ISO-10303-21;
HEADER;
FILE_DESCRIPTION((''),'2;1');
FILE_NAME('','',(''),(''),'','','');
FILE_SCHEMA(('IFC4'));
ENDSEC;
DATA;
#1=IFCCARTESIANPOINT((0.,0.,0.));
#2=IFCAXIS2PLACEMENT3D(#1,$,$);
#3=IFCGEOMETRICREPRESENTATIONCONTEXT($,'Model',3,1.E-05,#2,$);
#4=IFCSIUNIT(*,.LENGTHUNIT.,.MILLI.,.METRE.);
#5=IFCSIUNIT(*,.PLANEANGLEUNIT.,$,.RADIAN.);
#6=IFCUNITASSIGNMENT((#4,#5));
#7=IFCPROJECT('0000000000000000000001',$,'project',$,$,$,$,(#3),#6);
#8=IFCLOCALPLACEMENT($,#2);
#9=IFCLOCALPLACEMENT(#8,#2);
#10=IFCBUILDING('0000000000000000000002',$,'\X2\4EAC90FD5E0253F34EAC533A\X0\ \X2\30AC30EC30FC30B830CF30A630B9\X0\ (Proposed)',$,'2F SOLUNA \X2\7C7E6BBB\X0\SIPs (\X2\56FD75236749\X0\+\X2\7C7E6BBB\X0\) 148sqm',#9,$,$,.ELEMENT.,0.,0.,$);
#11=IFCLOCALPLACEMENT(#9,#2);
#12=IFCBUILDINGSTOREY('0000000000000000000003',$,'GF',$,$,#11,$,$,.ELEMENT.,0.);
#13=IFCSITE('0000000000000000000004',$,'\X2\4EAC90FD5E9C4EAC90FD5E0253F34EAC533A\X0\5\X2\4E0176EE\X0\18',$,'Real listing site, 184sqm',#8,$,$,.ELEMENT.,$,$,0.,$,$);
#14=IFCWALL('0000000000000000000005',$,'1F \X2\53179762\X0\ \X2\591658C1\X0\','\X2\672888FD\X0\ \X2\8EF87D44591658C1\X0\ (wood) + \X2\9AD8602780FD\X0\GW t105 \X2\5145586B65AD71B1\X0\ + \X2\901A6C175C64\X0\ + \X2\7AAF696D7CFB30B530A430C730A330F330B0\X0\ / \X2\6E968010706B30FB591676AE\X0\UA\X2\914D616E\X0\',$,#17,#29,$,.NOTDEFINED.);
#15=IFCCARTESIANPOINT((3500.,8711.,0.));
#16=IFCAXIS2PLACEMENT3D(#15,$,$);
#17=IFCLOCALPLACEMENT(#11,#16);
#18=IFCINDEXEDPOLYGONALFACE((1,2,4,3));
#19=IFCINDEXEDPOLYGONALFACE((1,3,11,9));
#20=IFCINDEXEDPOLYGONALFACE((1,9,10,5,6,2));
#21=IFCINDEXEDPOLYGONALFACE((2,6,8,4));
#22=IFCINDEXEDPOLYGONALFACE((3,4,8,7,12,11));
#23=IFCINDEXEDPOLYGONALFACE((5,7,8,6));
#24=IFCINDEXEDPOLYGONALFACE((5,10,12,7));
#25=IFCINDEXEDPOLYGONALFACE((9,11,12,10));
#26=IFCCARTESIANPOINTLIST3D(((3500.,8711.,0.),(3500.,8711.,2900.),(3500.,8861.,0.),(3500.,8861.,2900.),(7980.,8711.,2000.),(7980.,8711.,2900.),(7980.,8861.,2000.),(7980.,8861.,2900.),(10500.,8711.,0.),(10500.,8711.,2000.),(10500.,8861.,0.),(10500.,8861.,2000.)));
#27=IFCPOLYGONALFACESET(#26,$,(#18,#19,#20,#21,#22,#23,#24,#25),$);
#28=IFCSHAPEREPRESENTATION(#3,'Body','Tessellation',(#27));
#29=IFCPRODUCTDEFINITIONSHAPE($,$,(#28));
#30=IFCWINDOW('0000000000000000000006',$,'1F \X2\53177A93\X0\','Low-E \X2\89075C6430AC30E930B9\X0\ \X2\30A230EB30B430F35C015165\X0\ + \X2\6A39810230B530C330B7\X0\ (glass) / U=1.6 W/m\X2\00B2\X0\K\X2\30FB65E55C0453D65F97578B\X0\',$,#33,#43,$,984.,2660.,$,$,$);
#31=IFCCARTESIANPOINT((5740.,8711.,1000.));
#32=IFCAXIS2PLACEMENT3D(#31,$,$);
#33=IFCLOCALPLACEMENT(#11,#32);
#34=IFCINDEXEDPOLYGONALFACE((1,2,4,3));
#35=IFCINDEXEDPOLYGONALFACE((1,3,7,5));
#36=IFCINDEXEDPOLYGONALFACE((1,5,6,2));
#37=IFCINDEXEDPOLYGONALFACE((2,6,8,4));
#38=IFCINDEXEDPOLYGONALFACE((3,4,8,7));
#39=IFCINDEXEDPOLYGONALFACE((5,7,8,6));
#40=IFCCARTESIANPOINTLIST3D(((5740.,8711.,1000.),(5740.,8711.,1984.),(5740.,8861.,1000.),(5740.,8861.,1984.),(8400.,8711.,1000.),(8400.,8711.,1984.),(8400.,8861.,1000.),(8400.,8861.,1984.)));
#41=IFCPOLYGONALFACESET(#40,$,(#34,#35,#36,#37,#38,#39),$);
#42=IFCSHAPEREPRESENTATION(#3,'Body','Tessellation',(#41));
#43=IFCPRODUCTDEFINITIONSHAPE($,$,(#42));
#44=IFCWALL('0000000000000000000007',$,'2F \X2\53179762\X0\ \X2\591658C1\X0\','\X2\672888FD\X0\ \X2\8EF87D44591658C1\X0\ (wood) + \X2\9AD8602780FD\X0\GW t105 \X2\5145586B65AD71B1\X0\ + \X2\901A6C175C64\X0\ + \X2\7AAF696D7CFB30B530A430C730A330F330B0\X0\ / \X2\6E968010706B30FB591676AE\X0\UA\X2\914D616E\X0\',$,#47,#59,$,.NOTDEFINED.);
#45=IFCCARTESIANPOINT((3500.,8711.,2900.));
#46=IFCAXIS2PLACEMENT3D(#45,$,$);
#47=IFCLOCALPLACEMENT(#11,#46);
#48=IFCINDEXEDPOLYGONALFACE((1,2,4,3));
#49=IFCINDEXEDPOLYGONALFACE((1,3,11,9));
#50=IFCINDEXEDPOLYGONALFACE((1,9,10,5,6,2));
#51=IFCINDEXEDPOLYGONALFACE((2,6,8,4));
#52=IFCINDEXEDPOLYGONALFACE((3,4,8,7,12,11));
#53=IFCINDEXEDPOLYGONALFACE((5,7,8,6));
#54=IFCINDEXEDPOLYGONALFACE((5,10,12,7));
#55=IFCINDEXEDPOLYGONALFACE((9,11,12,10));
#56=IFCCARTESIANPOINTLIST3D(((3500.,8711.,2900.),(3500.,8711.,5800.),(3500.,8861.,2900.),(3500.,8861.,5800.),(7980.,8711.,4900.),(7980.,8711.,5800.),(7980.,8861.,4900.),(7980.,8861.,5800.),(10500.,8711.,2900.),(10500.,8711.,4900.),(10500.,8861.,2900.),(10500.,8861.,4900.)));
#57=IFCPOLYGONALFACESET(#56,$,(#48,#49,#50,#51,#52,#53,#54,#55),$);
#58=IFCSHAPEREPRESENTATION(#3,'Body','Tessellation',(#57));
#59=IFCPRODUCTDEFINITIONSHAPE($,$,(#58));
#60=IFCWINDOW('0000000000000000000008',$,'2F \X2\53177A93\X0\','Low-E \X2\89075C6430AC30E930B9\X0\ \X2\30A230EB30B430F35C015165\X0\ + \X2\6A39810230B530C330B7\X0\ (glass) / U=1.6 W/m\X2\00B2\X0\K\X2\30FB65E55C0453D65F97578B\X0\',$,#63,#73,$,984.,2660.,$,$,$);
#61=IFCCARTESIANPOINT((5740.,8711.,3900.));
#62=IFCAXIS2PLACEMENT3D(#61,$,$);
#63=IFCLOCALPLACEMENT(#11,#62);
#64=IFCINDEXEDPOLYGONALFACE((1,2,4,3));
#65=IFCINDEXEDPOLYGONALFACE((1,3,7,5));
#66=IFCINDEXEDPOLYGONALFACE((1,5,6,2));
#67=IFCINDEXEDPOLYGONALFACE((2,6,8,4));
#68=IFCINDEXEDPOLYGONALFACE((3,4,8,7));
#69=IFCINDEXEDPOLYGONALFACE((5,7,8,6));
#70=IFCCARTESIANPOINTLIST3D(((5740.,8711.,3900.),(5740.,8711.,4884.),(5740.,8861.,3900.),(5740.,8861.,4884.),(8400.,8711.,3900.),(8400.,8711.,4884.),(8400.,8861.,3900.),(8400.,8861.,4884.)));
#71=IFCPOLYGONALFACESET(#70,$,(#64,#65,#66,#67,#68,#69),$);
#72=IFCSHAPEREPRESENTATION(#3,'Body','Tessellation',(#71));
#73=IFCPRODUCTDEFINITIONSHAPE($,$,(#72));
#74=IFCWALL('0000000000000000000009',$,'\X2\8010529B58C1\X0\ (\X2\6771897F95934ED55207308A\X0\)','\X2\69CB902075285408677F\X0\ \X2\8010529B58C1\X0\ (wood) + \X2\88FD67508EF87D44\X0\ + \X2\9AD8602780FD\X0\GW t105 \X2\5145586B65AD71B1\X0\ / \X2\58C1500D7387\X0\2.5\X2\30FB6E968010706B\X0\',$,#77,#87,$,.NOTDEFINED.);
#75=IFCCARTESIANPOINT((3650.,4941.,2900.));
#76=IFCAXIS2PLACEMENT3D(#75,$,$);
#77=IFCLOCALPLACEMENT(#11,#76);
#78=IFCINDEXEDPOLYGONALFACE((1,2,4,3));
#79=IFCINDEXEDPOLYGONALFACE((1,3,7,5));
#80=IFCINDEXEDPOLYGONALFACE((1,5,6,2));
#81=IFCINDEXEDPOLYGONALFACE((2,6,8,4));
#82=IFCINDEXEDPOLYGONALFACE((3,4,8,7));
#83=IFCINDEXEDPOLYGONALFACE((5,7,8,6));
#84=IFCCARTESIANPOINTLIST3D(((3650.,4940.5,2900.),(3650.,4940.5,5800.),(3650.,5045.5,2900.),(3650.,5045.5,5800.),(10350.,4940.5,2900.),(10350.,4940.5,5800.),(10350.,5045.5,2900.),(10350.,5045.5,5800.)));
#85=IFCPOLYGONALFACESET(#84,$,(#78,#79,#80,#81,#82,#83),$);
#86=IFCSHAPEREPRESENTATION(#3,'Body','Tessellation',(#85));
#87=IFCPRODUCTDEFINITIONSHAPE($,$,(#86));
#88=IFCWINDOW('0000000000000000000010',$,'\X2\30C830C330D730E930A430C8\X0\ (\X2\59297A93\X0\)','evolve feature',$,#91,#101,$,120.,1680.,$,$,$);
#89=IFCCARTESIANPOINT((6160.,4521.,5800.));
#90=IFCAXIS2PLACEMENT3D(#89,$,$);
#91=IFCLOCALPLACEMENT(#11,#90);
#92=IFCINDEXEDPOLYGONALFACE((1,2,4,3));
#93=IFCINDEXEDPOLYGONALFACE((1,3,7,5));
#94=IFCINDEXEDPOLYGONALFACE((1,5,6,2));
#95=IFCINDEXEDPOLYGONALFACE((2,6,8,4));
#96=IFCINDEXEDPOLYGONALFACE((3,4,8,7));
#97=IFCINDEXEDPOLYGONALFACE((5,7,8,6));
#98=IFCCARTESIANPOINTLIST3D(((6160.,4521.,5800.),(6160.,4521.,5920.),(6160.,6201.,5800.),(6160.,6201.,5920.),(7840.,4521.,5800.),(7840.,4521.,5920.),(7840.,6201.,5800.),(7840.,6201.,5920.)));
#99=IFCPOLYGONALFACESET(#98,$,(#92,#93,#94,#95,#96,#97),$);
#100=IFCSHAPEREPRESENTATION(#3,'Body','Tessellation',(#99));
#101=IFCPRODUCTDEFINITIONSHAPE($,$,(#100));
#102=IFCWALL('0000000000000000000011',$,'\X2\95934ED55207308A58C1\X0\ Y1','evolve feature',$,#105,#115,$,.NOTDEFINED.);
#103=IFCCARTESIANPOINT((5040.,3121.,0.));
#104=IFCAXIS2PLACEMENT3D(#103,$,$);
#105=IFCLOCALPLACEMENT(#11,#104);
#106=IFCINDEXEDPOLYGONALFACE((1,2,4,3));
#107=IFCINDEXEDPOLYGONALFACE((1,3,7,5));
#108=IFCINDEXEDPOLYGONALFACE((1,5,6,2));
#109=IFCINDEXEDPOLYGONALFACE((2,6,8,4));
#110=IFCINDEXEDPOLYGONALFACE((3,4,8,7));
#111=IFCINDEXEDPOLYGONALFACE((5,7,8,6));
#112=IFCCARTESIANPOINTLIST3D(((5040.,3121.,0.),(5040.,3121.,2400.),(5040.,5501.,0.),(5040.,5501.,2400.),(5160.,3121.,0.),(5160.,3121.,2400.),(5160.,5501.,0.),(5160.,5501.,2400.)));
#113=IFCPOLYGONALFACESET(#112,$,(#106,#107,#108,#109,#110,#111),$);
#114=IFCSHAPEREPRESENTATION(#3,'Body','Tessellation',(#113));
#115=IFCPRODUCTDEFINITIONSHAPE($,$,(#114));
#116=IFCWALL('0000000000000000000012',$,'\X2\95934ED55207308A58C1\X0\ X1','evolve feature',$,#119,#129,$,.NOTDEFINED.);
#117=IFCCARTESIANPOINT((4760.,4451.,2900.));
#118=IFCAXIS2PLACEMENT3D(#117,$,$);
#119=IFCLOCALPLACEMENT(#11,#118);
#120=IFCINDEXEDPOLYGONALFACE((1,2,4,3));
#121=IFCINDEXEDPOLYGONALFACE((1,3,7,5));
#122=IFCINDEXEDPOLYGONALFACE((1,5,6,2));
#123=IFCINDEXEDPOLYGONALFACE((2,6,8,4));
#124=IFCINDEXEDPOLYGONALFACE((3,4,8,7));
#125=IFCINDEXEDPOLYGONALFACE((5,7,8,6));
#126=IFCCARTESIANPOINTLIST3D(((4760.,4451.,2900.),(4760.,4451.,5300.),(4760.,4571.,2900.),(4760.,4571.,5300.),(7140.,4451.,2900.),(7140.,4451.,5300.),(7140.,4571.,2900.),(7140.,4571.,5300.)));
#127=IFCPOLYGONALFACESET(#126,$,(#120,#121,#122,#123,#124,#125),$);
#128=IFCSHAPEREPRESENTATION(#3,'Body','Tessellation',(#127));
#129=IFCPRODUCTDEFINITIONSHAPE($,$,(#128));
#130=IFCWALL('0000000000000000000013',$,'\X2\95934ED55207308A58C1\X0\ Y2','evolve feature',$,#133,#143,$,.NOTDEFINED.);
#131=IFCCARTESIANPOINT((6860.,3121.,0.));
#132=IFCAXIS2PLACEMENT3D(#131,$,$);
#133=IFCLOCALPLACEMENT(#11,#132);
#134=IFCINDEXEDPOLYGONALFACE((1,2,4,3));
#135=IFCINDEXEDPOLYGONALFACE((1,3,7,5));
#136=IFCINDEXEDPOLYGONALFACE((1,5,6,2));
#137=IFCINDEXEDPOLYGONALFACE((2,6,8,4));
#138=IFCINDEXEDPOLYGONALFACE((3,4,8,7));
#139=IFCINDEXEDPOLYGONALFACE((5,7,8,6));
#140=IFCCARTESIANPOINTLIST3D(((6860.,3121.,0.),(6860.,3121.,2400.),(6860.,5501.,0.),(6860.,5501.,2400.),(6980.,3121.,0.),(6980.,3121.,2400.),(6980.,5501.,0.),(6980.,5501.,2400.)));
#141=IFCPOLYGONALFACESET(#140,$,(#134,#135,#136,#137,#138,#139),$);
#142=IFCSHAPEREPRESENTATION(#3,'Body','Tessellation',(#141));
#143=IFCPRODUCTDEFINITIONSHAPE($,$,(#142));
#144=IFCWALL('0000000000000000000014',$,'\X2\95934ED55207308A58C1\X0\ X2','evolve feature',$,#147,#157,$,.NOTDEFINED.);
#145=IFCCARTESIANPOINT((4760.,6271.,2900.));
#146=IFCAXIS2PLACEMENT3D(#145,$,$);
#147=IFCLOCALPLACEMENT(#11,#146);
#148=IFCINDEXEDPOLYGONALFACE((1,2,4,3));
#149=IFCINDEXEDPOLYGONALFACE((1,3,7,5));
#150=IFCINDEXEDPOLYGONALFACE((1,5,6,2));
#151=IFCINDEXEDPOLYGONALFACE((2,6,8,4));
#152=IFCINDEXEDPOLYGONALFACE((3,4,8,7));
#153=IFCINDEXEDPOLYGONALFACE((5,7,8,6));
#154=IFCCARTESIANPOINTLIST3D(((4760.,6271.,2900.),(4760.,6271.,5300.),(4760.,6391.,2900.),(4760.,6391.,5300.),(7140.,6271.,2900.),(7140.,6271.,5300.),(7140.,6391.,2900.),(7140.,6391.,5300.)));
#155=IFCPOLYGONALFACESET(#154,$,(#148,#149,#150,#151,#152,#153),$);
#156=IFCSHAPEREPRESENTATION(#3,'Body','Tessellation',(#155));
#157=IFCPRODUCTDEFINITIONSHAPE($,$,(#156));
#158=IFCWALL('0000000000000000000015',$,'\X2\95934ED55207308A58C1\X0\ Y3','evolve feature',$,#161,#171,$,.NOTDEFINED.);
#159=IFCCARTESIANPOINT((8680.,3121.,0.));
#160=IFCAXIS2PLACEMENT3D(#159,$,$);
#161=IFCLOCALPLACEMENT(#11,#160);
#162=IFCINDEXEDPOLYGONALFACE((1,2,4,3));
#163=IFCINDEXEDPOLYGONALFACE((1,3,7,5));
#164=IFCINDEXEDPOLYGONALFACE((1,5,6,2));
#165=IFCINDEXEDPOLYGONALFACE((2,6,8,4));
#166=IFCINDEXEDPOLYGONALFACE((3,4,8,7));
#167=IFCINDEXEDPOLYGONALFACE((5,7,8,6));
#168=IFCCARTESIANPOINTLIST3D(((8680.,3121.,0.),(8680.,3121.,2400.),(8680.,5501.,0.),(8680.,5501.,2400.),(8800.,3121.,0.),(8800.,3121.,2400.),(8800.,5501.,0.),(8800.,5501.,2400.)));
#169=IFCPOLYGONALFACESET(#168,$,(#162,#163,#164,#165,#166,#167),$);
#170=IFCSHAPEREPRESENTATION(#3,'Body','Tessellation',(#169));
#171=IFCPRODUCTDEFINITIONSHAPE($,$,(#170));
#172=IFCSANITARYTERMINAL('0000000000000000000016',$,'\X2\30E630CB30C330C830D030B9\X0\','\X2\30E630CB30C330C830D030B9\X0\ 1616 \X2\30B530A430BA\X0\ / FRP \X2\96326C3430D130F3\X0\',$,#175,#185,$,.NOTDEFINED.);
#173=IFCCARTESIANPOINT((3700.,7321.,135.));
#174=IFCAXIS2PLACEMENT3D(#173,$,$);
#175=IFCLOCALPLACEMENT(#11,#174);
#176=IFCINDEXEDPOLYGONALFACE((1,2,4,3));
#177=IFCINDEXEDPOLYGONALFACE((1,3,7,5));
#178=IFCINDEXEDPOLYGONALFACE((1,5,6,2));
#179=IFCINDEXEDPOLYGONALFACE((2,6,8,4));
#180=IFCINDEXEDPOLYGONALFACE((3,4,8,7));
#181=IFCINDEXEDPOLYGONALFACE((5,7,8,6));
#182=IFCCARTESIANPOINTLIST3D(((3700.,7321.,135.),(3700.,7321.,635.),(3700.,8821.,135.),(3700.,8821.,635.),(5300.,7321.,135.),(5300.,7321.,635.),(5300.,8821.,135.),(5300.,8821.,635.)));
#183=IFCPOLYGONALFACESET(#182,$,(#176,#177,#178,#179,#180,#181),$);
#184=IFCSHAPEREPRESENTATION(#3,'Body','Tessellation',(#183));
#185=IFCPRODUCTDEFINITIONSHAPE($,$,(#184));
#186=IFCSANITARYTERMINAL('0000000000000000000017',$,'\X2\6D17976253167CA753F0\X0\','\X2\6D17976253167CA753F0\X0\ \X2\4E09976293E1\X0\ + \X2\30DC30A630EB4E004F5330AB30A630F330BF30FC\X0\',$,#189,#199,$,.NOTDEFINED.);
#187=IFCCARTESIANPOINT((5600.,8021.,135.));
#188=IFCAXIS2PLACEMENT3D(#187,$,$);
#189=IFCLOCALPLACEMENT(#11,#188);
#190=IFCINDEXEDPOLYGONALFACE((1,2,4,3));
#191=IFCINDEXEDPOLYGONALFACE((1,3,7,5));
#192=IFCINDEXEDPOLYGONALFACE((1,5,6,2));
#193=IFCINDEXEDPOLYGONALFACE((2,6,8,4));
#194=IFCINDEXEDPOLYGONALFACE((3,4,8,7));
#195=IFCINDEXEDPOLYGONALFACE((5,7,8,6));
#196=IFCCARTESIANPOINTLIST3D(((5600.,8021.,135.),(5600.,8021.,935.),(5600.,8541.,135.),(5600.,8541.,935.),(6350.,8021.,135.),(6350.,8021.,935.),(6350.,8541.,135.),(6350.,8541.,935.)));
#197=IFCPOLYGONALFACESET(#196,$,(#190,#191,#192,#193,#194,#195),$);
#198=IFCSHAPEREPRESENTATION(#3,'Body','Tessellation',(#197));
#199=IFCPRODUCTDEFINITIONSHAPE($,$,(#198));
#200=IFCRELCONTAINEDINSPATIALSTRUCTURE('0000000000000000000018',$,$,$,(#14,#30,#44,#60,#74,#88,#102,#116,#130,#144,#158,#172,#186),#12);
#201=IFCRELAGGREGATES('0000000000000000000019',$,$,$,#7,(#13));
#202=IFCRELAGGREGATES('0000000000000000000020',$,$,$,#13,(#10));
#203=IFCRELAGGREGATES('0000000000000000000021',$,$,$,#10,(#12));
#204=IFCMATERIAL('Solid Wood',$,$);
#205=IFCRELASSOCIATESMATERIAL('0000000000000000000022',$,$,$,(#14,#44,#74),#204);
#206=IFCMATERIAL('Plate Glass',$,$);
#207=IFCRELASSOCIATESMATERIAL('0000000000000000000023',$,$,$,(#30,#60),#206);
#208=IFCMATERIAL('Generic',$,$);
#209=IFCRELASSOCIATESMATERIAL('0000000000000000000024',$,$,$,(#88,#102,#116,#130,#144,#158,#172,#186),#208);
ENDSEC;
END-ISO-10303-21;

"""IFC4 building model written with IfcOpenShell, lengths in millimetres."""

from ifc_helpers import new_model, si_unit, frame, frame_2d, origin, place, context, project, spatial, rectangle, extrude, material, element, fill, save


model = new_model("IFC4")

# Units and contexts
model_context = context("Model", 3, precision=1e-05, world=origin())
ifc_project = project(units=[si_unit("LENGTHUNIT", "METRE", prefix="MILLI"), si_unit("PLANEANGLEUNIT", "RADIAN")], contexts=[model_context])

# Site, building, storey
site_placement = place(None, origin())
site = spatial("IfcSite", under=ifc_project, at=site_placement, Name="京都府京都市右京区5丁目18", ObjectType="Real listing site, 184sqm", CompositionType="ELEMENT", RefElevation=0.0)
building_placement = place(site_placement, origin())
building = spatial("IfcBuilding", under=site, at=building_placement, Name="京都市右京区 ガレージハウス (Proposed)", ObjectType="2F SOLUNA 籾殻SIPs (国産杉+籾殻) 148sqm", CompositionType="ELEMENT", ElevationOfRefHeight=0.0, ElevationOfTerrain=0.0)
storey_placement = place(building_placement, origin())
storey = spatial("IfcBuildingStorey", under=building, at=storey_placement, Name="GF", CompositionType="ELEMENT", Elevation=0.0)

# Wall, opening, window
ifc_material_1 = material(Name="Solid Wood")
wall_1_placement = place(storey_placement, frame((3500.0, 8711.0, 0.0)))
wall_1 = element("IfcWall", 1, at=wall_1_placement, inside=storey, material=ifc_material_1, Name="1F 北面 外壁", Description="木製 軸組外壁 (wood) + 高性能GW t105 充填断熱 + 通気層 + 窯業系サイディング / 準耐火・外皮UA配慮", PredefinedType="NOTDEFINED", context=model_context, shape_type="SweptSolid", body=[
    extrude(rectangle(XDim=7000.0, YDim=150.0, at=frame_2d((3500.0, 75.0))), frame((3500.0, 8711.0, 0.0)), (0.0, 0.0, 1.0), 2900.0),
])
opening_1_placement = place(storey_placement, frame((5740.0, 8711.0, 1000.0)))
opening_1 = element("IfcOpeningElement", 2, at=opening_1_placement, cuts=wall_1, PredefinedType="NOTDEFINED", context=model_context, shape_type="SweptSolid", body=[
    extrude(rectangle(XDim=2660.0, YDim=150.0, at=frame_2d((1330.0, 75.0))), frame((5740.0, 8711.0, 1000.0)), (0.0, 0.0, 1.0), 984.0),
])
ifc_material_2 = material(Name="Plate Glass")
window_1_placement = place(storey_placement, frame((5740.0, 8711.0, 1000.0)))
window_1 = element("IfcWindow", 3, at=window_1_placement, inside=storey, material=ifc_material_2, Name="1F 北窓", Description="Low-E 複層ガラス アルゴン封入 + 樹脂サッシ (glass) / U=1.6 W/m²K・日射取得型", OverallHeight=984.0, OverallWidth=2660.0, context=model_context, shape_type="SweptSolid", body=[
    extrude(rectangle(XDim=2660.0, YDim=150.0, at=frame_2d((1330.0, 75.0))), frame((5740.0, 8711.0, 1000.0)), (0.0, 0.0, 1.0), 984.0),
])
fill(opening_1, window_1)

# Wall, opening, window
wall_2_placement = place(storey_placement, frame((3500.0, 8711.0, 2900.0)))
wall_2 = element("IfcWall", 4, at=wall_2_placement, inside=storey, material=ifc_material_1, Name="2F 北面 外壁", Description="木製 軸組外壁 (wood) + 高性能GW t105 充填断熱 + 通気層 + 窯業系サイディング / 準耐火・外皮UA配慮", PredefinedType="NOTDEFINED", context=model_context, shape_type="SweptSolid", body=[
    extrude(rectangle(XDim=7000.0, YDim=150.0, at=frame_2d((3500.0, 75.0))), frame((3500.0, 8711.0, 2900.0)), (0.0, 0.0, 1.0), 2900.0),
])
opening_2_placement = place(storey_placement, frame((5740.0, 8711.0, 3900.0)))
opening_2 = element("IfcOpeningElement", 5, at=opening_2_placement, cuts=wall_2, PredefinedType="NOTDEFINED", context=model_context, shape_type="SweptSolid", body=[
    extrude(rectangle(XDim=2660.0, YDim=150.0, at=frame_2d((1330.0, 75.0))), frame((5740.0, 8711.0, 3900.0)), (0.0, 0.0, 1.0), 984.0),
])
window_2_placement = place(storey_placement, frame((5740.0, 8711.0, 3900.0)))
window_2 = element("IfcWindow", 6, at=window_2_placement, inside=storey, material=ifc_material_2, Name="2F 北窓", Description="Low-E 複層ガラス アルゴン封入 + 樹脂サッシ (glass) / U=1.6 W/m²K・日射取得型", OverallHeight=984.0, OverallWidth=2660.0, context=model_context, shape_type="SweptSolid", body=[
    extrude(rectangle(XDim=2660.0, YDim=150.0, at=frame_2d((1330.0, 75.0))), frame((5740.0, 8711.0, 3900.0)), (0.0, 0.0, 1.0), 984.0),
])
fill(opening_2, window_2)

# Wall
wall_3_placement = place(storey_placement, frame((3650.0, 4941.0, 2900.0)))
element("IfcWall", 7, at=wall_3_placement, inside=storey, material=ifc_material_1, Name="耐力壁 (東西間仕切り)", Description="構造用合板 耐力壁 (wood) + 製材軸組 + 高性能GW t105 充填断熱 / 壁倍率2.5・準耐火", PredefinedType="NOTDEFINED", context=model_context, shape_type="SweptSolid", body=[
    extrude(rectangle(XDim=6700.0, YDim=105.0, at=frame_2d((3350.0, 52.0))), frame((3650.0, 4941.0, 2900.0)), (0.0, 0.0, 1.0), 2900.0),
])

# Window
ifc_material_3 = material(Name="Generic")
window_3_placement = place(storey_placement, frame((6160.0, 4521.0, 5800.0)))
element("IfcWindow", 8, at=window_3_placement, inside=storey, material=ifc_material_3, Name="トップライト (天窓)", Description="evolve feature", OverallHeight=120.0, OverallWidth=1680.0, context=model_context, shape_type="SweptSolid", body=[
    extrude(rectangle(XDim=1680.0, YDim=1680.0, at=frame_2d((840.0, 840.0))), frame((6160.0, 4521.0, 5800.0)), (0.0, 0.0, 1.0), 120.0),
])

# Walls
wall_4_placement = place(storey_placement, frame((5040.0, 3121.0, 0.0)))
element("IfcWall", 9, at=wall_4_placement, inside=storey, material=ifc_material_3, Name="間仕切り壁 Y1", Description="evolve feature", PredefinedType="NOTDEFINED", context=model_context, shape_type="SweptSolid", body=[
    extrude(rectangle(XDim=120.0, YDim=2380.0, at=frame_2d((60.0, 1190.0))), frame((5040.0, 3121.0, 0.0)), (0.0, 0.0, 1.0), 2400.0),
])
wall_5_placement = place(storey_placement, frame((4760.0, 4451.0, 2900.0)))
element("IfcWall", 10, at=wall_5_placement, inside=storey, material=ifc_material_3, Name="間仕切り壁 X1", Description="evolve feature", PredefinedType="NOTDEFINED", context=model_context, shape_type="SweptSolid", body=[
    extrude(rectangle(XDim=2380.0, YDim=120.0, at=frame_2d((1190.0, 60.0))), frame((4760.0, 4451.0, 2900.0)), (0.0, 0.0, 1.0), 2400.0),
])
wall_6_placement = place(storey_placement, frame((6860.0, 3121.0, 0.0)))
element("IfcWall", 11, at=wall_6_placement, inside=storey, material=ifc_material_3, Name="間仕切り壁 Y2", Description="evolve feature", PredefinedType="NOTDEFINED", context=model_context, shape_type="SweptSolid", body=[
    extrude(rectangle(XDim=120.0, YDim=2380.0, at=frame_2d((60.0, 1190.0))), frame((6860.0, 3121.0, 0.0)), (0.0, 0.0, 1.0), 2400.0),
])
wall_7_placement = place(storey_placement, frame((4760.0, 6271.0, 2900.0)))
element("IfcWall", 12, at=wall_7_placement, inside=storey, material=ifc_material_3, Name="間仕切り壁 X2", Description="evolve feature", PredefinedType="NOTDEFINED", context=model_context, shape_type="SweptSolid", body=[
    extrude(rectangle(XDim=2380.0, YDim=120.0, at=frame_2d((1190.0, 60.0))), frame((4760.0, 6271.0, 2900.0)), (0.0, 0.0, 1.0), 2400.0),
])
wall_8_placement = place(storey_placement, frame((8680.0, 3121.0, 0.0)))
element("IfcWall", 13, at=wall_8_placement, inside=storey, material=ifc_material_3, Name="間仕切り壁 Y3", Description="evolve feature", PredefinedType="NOTDEFINED", context=model_context, shape_type="SweptSolid", body=[
    extrude(rectangle(XDim=120.0, YDim=2380.0, at=frame_2d((60.0, 1190.0))), frame((8680.0, 3121.0, 0.0)), (0.0, 0.0, 1.0), 2400.0),
])

# Sanitary terminals
sanitary_terminal_1_placement = place(storey_placement, frame((3700.0, 7321.0, 135.0)))
element("IfcSanitaryTerminal", 14, at=sanitary_terminal_1_placement, inside=storey, material=ifc_material_3, Name="ユニットバス", Description="ユニットバス 1616 サイズ / FRP 防水パン", PredefinedType="NOTDEFINED", context=model_context, shape_type="SweptSolid", body=[
    extrude(rectangle(XDim=1600.0, YDim=1500.0, at=frame_2d((800.0, 750.0))), frame((3700.0, 7321.0, 135.0)), (0.0, 0.0, 1.0), 500.0),
])
sanitary_terminal_2_placement = place(storey_placement, frame((5600.0, 8021.0, 135.0)))
element("IfcSanitaryTerminal", 15, at=sanitary_terminal_2_placement, inside=storey, material=ifc_material_3, Name="洗面化粧台", Description="洗面化粧台 三面鏡 + ボウル一体カウンター", PredefinedType="NOTDEFINED", context=model_context, shape_type="SweptSolid", body=[
    extrude(rectangle(XDim=750.0, YDim=520.0, at=frame_2d((375.0, 260.0))), frame((5600.0, 8021.0, 135.0)), (0.0, 0.0, 1.0), 800.0),
])

save(model, "model.ifc")
